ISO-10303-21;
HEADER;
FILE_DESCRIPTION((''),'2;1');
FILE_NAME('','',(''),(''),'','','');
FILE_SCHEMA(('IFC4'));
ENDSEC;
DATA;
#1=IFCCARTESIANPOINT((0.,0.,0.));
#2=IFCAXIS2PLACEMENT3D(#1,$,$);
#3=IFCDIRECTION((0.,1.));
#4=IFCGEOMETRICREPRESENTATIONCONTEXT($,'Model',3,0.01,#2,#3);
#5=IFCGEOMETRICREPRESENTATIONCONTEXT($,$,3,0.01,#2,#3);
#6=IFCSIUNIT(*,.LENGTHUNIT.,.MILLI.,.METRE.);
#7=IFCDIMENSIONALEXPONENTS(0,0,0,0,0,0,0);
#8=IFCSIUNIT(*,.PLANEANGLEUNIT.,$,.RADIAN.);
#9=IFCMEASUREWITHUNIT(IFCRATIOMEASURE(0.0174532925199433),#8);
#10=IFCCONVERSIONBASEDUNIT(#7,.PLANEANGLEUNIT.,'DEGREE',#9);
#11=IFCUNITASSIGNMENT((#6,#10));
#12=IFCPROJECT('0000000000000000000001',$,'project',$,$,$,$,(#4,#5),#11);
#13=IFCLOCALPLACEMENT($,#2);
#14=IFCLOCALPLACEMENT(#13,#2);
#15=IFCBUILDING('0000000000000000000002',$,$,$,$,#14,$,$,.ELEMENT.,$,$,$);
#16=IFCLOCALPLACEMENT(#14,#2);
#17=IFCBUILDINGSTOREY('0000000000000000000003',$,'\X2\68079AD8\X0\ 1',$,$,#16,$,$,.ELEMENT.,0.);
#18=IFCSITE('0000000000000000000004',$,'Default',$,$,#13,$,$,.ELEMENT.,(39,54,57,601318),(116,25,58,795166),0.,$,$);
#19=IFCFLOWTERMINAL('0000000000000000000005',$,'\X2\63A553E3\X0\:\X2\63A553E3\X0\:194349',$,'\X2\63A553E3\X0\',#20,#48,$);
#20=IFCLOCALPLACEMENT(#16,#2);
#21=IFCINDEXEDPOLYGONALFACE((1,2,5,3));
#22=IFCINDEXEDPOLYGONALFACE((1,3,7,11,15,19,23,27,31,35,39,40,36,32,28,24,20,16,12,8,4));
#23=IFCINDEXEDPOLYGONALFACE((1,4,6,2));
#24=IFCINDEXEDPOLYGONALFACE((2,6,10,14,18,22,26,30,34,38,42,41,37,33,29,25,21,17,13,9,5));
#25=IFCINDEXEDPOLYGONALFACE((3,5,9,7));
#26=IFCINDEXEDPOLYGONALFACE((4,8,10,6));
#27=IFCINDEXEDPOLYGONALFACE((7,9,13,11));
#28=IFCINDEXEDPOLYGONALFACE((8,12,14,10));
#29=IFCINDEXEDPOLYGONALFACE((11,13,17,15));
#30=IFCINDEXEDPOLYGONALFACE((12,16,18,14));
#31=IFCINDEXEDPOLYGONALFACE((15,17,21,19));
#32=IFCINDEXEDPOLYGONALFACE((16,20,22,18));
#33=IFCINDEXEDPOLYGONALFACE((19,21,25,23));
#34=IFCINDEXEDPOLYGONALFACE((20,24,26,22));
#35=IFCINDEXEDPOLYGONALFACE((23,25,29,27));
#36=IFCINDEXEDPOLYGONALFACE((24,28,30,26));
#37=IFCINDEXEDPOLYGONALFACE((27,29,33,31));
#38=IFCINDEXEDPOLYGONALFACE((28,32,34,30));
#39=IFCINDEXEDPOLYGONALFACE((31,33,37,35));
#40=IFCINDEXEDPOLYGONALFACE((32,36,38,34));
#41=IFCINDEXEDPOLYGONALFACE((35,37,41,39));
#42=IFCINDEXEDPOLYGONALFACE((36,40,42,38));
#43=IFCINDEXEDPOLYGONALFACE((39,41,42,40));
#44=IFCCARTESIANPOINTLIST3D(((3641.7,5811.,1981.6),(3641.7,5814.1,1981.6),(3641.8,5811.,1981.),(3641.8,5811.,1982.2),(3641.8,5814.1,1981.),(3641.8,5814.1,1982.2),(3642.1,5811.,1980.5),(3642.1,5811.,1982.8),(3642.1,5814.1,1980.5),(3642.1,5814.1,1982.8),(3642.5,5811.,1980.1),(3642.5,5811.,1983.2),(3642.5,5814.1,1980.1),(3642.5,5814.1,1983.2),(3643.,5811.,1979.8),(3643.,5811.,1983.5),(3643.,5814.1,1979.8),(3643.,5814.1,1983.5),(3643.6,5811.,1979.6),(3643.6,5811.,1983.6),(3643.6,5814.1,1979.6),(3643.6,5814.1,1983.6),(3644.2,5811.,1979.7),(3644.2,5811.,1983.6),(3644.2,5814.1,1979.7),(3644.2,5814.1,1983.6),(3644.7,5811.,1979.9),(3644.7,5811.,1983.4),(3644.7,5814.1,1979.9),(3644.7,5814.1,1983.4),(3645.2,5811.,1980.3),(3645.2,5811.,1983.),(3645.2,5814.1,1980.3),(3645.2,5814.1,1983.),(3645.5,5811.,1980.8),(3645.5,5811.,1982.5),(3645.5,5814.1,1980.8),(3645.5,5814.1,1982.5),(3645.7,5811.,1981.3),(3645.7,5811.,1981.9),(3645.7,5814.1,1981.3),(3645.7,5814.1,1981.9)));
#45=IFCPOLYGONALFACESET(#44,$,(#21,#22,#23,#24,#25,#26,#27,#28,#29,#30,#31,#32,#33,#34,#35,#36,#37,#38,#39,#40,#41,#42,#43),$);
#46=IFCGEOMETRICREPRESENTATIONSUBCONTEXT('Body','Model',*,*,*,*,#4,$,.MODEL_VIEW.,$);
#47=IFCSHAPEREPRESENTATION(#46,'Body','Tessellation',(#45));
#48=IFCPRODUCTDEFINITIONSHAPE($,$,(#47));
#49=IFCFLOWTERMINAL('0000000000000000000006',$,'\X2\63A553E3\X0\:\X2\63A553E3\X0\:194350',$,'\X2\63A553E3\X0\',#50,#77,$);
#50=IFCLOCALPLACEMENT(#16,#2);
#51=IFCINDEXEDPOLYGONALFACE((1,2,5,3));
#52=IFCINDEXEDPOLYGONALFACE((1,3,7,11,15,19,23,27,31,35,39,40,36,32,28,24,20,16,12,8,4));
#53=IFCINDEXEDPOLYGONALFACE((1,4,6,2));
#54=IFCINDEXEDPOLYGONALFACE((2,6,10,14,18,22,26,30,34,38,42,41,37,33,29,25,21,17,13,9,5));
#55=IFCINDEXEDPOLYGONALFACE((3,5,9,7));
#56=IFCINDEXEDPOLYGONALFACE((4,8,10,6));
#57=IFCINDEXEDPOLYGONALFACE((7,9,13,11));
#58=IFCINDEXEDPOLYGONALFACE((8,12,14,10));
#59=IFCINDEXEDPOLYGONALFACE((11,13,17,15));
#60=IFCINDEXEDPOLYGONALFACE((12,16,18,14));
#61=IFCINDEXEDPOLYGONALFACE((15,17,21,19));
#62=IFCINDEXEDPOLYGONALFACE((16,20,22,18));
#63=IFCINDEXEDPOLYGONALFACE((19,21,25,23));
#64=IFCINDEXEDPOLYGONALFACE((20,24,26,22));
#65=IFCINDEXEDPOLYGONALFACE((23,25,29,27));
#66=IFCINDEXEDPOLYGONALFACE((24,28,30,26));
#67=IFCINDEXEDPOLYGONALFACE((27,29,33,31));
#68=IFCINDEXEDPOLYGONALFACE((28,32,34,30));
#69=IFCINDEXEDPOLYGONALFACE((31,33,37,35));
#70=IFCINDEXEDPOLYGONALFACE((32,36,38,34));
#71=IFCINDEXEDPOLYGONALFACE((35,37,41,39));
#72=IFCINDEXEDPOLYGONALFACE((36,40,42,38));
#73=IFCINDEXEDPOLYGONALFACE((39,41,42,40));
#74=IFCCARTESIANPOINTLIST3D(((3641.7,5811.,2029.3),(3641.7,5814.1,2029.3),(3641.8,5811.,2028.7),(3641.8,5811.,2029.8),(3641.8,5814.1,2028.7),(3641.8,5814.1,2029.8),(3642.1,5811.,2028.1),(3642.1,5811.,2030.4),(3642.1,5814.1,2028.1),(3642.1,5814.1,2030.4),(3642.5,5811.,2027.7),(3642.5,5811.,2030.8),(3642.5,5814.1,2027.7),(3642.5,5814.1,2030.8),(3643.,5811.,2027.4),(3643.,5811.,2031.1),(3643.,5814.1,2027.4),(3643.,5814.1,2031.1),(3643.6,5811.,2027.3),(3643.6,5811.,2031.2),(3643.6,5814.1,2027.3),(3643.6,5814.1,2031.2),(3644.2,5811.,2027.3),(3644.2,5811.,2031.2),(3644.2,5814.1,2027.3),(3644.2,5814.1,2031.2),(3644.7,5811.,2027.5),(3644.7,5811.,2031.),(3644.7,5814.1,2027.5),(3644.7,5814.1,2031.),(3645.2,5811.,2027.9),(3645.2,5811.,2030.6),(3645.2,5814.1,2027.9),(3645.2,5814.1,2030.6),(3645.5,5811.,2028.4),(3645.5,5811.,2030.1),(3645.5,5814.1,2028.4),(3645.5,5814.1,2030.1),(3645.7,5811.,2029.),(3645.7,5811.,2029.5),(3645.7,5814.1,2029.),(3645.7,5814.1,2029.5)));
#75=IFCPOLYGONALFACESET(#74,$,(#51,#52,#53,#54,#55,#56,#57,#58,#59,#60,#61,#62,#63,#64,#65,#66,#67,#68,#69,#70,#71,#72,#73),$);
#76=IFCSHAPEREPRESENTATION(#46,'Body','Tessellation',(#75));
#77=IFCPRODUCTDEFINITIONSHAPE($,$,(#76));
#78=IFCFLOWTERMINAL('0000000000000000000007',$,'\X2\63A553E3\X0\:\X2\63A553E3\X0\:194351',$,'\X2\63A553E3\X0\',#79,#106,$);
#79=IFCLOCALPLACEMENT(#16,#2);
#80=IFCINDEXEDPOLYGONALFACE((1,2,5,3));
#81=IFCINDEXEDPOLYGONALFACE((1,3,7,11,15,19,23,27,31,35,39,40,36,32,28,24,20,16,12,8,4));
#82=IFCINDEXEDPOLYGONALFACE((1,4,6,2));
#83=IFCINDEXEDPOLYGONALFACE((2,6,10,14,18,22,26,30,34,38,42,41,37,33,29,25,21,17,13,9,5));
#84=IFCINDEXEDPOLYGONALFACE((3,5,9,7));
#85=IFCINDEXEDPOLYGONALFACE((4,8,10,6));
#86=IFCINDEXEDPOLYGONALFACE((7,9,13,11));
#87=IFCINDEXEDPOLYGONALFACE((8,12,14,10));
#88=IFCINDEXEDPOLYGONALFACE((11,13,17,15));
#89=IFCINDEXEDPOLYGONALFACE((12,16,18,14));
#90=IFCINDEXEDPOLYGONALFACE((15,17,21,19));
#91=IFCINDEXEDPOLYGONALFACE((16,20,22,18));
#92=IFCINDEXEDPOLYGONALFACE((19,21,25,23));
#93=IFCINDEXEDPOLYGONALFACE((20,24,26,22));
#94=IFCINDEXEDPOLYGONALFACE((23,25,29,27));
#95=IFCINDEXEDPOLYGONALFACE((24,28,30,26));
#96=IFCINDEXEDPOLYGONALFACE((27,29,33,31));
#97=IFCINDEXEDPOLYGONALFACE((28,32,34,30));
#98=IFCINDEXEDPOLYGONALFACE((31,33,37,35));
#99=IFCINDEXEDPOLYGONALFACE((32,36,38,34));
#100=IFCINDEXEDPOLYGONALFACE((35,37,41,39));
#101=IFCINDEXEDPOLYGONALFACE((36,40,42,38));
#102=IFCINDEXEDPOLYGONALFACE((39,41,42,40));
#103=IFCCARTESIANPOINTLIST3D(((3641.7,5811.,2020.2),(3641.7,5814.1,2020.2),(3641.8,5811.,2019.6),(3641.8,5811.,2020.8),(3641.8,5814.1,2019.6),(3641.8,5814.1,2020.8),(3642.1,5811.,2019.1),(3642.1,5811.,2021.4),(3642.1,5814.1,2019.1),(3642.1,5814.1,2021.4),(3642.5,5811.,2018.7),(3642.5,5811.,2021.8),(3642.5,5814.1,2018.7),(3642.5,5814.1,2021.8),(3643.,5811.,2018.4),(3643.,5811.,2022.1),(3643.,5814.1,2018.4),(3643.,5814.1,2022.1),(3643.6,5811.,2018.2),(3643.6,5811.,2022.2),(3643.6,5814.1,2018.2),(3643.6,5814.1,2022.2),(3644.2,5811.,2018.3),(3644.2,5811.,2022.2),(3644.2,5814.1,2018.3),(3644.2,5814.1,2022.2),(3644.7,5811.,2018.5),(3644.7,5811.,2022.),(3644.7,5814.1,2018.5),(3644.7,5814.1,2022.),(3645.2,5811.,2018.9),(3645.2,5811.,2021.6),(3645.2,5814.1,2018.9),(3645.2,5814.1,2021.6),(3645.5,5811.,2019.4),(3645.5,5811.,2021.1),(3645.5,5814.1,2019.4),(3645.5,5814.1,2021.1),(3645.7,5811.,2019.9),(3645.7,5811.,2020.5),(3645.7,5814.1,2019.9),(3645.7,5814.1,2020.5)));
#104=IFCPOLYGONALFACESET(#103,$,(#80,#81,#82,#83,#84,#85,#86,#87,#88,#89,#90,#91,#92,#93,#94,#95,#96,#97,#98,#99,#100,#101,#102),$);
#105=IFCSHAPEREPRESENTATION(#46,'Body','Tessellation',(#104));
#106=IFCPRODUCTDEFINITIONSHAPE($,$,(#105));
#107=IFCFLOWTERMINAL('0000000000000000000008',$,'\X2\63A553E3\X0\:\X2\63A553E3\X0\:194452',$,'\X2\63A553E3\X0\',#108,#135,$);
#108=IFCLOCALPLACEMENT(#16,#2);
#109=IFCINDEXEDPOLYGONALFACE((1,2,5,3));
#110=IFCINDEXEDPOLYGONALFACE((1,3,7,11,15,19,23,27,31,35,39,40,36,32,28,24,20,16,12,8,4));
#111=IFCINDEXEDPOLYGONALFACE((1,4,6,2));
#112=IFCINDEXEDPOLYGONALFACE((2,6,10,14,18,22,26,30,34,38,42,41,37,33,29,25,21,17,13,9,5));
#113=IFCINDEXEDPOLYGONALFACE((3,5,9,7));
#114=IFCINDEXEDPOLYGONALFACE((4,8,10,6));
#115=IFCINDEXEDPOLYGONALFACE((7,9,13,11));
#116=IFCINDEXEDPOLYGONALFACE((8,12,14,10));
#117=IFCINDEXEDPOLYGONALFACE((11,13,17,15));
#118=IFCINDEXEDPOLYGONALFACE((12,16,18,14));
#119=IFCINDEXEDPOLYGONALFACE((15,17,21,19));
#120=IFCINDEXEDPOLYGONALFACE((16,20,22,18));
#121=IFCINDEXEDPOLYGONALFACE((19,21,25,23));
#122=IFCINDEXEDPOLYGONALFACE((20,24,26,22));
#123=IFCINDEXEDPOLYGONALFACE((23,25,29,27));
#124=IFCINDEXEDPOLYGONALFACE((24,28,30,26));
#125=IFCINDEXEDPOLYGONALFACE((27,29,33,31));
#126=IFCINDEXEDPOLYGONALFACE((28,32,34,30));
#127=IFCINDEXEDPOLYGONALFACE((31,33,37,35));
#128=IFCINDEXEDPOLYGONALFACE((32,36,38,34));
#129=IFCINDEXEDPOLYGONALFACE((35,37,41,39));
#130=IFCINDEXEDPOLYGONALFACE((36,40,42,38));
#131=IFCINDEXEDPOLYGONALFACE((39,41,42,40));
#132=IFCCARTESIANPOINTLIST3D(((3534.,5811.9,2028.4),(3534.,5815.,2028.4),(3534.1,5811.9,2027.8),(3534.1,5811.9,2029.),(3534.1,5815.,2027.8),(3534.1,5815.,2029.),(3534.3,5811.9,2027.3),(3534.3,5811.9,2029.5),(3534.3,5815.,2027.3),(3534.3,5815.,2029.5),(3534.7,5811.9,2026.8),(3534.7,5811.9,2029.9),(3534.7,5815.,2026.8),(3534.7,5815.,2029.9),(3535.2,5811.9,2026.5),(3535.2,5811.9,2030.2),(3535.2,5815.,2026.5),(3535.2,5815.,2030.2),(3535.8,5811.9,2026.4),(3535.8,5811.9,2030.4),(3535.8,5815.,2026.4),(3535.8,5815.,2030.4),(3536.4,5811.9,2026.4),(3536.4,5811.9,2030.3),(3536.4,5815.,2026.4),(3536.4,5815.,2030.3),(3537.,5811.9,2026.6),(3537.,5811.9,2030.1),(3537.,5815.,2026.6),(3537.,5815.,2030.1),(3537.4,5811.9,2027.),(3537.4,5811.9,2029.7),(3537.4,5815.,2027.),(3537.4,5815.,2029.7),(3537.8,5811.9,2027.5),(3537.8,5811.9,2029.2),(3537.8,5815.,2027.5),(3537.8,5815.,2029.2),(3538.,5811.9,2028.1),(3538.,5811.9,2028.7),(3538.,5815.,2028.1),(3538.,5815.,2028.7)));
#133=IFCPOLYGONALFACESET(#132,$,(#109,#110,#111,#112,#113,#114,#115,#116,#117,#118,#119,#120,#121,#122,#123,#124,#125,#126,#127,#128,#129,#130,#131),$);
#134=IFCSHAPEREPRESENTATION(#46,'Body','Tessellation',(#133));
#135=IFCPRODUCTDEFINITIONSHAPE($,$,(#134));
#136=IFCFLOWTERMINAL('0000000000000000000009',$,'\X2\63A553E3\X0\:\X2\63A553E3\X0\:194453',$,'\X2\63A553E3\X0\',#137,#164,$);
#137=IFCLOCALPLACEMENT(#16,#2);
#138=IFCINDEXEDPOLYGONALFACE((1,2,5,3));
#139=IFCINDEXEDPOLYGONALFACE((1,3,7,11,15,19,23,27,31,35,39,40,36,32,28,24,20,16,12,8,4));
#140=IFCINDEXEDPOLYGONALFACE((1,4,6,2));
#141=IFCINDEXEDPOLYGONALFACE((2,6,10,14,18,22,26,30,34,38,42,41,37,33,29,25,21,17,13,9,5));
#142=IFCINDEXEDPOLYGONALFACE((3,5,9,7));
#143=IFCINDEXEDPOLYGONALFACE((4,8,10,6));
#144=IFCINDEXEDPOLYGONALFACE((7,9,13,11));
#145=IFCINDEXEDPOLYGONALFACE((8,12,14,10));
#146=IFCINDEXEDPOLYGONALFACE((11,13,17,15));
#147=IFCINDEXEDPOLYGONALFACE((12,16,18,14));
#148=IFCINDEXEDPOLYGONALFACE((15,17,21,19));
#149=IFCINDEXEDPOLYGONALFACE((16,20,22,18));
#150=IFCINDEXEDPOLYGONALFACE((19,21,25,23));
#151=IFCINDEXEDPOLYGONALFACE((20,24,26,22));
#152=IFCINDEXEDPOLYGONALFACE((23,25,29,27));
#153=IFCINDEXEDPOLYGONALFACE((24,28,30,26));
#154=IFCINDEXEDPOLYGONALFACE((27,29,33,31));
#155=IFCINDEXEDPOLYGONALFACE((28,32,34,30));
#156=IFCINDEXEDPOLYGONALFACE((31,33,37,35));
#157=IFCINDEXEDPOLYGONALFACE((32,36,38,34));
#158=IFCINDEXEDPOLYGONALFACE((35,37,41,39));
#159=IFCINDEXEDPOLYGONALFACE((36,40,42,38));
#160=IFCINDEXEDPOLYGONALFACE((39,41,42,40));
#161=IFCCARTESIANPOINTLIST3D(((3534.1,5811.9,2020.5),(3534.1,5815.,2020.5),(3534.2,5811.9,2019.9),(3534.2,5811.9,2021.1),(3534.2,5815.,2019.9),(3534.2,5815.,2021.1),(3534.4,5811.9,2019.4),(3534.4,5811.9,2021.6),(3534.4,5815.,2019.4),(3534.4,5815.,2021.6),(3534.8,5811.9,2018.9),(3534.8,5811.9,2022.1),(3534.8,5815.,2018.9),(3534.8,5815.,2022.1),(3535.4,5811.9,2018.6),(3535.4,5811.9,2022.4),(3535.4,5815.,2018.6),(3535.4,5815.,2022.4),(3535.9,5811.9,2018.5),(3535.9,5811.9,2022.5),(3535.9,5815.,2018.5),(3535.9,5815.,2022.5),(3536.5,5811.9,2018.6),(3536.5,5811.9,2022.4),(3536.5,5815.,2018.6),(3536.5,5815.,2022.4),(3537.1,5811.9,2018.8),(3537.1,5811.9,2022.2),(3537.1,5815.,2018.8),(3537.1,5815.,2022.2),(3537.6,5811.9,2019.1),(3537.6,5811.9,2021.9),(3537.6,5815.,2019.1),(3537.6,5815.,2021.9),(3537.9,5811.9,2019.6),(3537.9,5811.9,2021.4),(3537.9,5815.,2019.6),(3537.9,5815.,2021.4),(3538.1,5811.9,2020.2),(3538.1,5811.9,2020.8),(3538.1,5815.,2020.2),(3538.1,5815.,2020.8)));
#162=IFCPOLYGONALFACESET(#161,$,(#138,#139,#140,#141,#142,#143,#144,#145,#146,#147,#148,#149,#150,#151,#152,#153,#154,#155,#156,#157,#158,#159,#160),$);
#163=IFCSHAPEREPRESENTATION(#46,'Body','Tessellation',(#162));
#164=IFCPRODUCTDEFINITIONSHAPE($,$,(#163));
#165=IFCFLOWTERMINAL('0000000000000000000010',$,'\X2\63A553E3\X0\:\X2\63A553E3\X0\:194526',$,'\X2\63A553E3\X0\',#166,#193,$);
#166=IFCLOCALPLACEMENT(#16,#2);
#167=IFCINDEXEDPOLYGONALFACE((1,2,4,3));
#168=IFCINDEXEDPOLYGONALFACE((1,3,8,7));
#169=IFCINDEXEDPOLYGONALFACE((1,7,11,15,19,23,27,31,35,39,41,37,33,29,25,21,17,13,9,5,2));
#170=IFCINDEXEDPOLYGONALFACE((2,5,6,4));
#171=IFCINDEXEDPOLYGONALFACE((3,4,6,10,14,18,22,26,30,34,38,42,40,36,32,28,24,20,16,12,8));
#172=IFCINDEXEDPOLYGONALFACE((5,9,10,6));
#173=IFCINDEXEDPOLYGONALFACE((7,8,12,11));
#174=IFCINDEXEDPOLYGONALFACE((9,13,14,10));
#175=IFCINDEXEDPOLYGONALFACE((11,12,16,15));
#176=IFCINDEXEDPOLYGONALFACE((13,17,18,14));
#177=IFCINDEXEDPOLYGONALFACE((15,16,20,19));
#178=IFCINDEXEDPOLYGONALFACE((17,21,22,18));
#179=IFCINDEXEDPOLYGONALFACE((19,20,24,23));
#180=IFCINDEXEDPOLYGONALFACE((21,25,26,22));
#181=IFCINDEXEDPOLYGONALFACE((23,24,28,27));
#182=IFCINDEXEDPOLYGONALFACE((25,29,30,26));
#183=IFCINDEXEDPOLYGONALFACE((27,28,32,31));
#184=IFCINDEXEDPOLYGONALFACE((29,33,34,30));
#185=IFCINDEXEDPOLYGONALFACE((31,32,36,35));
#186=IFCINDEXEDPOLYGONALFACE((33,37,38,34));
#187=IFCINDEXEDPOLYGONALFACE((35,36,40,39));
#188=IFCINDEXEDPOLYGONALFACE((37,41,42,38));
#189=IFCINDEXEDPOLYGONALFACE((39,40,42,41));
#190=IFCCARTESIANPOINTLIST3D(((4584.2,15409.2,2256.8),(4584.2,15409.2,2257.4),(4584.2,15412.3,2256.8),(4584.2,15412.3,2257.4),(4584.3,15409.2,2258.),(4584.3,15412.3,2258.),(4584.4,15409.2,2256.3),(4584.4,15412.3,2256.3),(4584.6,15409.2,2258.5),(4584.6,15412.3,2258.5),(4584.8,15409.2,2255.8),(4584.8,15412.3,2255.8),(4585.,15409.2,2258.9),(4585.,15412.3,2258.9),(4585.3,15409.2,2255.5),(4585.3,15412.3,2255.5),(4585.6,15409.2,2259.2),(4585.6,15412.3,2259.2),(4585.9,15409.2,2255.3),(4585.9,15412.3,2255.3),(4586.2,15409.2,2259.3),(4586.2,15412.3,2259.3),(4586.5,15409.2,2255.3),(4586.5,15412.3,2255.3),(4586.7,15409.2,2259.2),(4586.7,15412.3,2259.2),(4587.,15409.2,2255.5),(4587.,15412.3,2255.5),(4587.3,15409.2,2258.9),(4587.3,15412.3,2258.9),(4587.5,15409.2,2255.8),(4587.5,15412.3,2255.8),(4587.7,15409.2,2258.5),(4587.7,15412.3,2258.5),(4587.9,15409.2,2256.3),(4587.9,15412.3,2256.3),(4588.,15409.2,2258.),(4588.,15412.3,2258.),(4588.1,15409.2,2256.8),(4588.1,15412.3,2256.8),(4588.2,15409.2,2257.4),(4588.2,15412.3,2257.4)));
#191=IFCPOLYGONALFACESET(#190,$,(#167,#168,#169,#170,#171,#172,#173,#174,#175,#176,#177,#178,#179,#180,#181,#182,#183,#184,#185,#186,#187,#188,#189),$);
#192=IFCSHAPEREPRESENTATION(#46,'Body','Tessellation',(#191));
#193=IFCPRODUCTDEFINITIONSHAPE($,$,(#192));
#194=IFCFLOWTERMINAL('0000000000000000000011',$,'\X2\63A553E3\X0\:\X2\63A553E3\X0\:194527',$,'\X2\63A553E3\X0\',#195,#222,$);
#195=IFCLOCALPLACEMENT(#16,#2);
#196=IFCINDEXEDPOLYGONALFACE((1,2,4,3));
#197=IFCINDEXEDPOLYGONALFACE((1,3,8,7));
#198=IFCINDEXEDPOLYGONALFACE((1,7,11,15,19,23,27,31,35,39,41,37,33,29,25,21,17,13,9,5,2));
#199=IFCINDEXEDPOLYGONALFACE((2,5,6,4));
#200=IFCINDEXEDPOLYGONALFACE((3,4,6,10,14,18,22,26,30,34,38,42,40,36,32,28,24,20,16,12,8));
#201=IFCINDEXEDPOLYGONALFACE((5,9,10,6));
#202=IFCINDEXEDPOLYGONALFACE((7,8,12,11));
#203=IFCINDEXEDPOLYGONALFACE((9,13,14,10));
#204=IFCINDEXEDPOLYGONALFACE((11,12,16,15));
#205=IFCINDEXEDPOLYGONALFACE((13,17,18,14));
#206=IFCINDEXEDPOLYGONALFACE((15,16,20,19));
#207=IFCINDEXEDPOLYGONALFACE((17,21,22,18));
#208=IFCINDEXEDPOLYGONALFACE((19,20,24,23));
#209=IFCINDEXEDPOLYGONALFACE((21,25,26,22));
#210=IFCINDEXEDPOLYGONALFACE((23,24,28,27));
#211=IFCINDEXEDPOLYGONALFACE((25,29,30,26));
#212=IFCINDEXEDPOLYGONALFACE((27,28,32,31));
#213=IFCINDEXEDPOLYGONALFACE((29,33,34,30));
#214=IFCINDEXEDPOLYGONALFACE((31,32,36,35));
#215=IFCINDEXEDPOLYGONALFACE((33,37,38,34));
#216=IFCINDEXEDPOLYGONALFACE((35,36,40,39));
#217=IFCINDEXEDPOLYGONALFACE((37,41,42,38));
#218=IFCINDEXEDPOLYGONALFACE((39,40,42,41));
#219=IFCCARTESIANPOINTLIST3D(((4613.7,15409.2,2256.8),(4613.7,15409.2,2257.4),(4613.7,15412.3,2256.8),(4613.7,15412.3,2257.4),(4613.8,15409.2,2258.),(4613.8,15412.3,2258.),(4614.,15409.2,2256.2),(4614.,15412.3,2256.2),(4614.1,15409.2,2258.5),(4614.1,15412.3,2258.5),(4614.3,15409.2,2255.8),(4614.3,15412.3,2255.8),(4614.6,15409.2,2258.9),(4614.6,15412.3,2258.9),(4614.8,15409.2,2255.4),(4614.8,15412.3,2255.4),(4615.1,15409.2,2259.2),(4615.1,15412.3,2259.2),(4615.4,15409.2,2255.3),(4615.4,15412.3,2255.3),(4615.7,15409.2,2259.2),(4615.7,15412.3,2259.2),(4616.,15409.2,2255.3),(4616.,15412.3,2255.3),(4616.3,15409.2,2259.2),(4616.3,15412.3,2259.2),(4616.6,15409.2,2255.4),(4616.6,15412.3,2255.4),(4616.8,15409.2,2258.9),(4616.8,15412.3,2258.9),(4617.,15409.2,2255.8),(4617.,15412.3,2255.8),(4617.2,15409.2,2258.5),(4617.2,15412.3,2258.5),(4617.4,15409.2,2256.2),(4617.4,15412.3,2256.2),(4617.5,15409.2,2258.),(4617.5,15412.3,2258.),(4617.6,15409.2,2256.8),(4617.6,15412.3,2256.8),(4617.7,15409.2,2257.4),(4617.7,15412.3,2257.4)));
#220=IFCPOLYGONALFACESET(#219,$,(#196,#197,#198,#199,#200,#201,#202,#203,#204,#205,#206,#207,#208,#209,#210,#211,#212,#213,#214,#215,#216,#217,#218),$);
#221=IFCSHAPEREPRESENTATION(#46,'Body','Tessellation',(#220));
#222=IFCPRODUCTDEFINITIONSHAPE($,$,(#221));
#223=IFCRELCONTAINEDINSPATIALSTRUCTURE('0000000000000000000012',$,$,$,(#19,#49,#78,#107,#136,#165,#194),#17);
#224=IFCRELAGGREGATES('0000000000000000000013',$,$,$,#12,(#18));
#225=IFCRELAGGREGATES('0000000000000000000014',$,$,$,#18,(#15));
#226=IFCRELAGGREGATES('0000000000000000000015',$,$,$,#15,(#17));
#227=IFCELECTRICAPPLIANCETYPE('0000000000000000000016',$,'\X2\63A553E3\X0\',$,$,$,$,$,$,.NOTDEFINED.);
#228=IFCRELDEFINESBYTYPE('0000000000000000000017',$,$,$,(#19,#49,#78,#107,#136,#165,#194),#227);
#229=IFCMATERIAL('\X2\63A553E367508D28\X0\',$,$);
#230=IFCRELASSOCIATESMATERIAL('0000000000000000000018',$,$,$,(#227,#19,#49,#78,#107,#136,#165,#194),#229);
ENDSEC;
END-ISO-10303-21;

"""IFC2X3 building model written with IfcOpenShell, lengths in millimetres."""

from ifc_helpers import new_model, entity, si_unit, converted_unit, direction, frame, frame_2d, origin, place, context, subcontext, project, spatial, circle, extrude, source, transform, mapped, material, type_object, type_shapes, element, save


model = new_model("IFC2X3")

# Units and contexts
model_context = context("Model", 3, precision=0.01, world=origin(), true_north=direction((0.0, 1.0)))
context_of_model = context(None, 3, precision=0.01, world=origin(), true_north=direction((0.0, 1.0)))
body_context = subcontext(model_context, "Body", "Model", "MODEL_VIEW")
ifc_project = project(units=[si_unit("LENGTHUNIT", "METRE", prefix="MILLI"), converted_unit("PLANEANGLEUNIT", "DEGREE", entity("IfcRatioMeasure", 0.0174532925199433), si_unit("PLANEANGLEUNIT", "RADIAN"), dimensions=[0, 0, 0, 0, 0, 0, 0])], contexts=[model_context, context_of_model])

# Site, building, storey
site_placement = place(None, origin())
site = spatial("IfcSite", under=ifc_project, at=site_placement, Name="Default", CompositionType="ELEMENT", RefLatitude=(39, 54, 57, 601318), RefLongitude=(116, 25, 58, 795166), RefElevation=0.0)
building_placement = place(site_placement, origin())
building = spatial("IfcBuilding", under=site, at=building_placement, CompositionType="ELEMENT")
storey_placement = place(building_placement, origin())
storey = spatial("IfcBuildingStorey", under=building, at=storey_placement, Name="标高 1", CompositionType="ELEMENT", Elevation=0.0)

# Flow terminals
ifc_material = material(Name="接口材质")
electric_appliance_type = type_object("IfcElectricApplianceType", Name="接口", PredefinedType="NOTDEFINED", material=ifc_material)
shared_shape = source(origin(), body_context, "Body", "SweptSolid", [
    extrude(circle(Radius=2.0, at=frame_2d((0.0, 0.0), x_axis=(1.0, 0.0))), origin(), (0.0, 0.0, 1.0), 3.1),
])
type_shapes(electric_appliance_type, [shared_shape])
for number, where, z_axis, x_axis, name in (
    (1, (3643.7, 5814.1, 1981.6), (0.0, -1.0, 0.0), (-1.0, 0.0, 0.0), "接口:接口:194349"),
    (2, (3643.7, 5814.1, 2029.3), (0.0, -1.0, 0.0), (-1.0, 0.0, 0.0), "接口:接口:194350"),
    (3, (3643.7, 5814.1, 2020.2), (0.0, -1.0, 0.0), (-1.0, 0.0, 0.0), "接口:接口:194351"),
    (4, (3536.0, 5815.0, 2028.4), (0.0, -1.0, 0.0), (-1.0, 0.0, 0.0), "接口:接口:194452"),
    (5, (3536.1, 5815.0, 2020.5), (0.0, -1.0, 0.0), (-1.0, 0.0, 0.0), "接口:接口:194453"),
    (6, (4586.2, 15412.3, 2257.3), (0.0, -1.0, 0.0), (0.0, 0.0, 1.0), "接口:接口:194526"),
    (7, (4615.7, 15412.3, 2257.2), (0.0, -1.0, 0.0), (0.0, 0.0, 1.0), "接口:接口:194527"),
):
    element("IfcFlowTerminal", number, at=place(storey_placement, frame(where, z_axis=z_axis, x_axis=x_axis)), inside=storey, type_object=electric_appliance_type, material=ifc_material, Name=name, ObjectType="接口", context=body_context, shape_type="MappedRepresentation", body=[
        mapped(shared_shape, transform((0.0, 0.0, 0.0), scale=1.0)),
    ])

save(model, "model.ifc")
